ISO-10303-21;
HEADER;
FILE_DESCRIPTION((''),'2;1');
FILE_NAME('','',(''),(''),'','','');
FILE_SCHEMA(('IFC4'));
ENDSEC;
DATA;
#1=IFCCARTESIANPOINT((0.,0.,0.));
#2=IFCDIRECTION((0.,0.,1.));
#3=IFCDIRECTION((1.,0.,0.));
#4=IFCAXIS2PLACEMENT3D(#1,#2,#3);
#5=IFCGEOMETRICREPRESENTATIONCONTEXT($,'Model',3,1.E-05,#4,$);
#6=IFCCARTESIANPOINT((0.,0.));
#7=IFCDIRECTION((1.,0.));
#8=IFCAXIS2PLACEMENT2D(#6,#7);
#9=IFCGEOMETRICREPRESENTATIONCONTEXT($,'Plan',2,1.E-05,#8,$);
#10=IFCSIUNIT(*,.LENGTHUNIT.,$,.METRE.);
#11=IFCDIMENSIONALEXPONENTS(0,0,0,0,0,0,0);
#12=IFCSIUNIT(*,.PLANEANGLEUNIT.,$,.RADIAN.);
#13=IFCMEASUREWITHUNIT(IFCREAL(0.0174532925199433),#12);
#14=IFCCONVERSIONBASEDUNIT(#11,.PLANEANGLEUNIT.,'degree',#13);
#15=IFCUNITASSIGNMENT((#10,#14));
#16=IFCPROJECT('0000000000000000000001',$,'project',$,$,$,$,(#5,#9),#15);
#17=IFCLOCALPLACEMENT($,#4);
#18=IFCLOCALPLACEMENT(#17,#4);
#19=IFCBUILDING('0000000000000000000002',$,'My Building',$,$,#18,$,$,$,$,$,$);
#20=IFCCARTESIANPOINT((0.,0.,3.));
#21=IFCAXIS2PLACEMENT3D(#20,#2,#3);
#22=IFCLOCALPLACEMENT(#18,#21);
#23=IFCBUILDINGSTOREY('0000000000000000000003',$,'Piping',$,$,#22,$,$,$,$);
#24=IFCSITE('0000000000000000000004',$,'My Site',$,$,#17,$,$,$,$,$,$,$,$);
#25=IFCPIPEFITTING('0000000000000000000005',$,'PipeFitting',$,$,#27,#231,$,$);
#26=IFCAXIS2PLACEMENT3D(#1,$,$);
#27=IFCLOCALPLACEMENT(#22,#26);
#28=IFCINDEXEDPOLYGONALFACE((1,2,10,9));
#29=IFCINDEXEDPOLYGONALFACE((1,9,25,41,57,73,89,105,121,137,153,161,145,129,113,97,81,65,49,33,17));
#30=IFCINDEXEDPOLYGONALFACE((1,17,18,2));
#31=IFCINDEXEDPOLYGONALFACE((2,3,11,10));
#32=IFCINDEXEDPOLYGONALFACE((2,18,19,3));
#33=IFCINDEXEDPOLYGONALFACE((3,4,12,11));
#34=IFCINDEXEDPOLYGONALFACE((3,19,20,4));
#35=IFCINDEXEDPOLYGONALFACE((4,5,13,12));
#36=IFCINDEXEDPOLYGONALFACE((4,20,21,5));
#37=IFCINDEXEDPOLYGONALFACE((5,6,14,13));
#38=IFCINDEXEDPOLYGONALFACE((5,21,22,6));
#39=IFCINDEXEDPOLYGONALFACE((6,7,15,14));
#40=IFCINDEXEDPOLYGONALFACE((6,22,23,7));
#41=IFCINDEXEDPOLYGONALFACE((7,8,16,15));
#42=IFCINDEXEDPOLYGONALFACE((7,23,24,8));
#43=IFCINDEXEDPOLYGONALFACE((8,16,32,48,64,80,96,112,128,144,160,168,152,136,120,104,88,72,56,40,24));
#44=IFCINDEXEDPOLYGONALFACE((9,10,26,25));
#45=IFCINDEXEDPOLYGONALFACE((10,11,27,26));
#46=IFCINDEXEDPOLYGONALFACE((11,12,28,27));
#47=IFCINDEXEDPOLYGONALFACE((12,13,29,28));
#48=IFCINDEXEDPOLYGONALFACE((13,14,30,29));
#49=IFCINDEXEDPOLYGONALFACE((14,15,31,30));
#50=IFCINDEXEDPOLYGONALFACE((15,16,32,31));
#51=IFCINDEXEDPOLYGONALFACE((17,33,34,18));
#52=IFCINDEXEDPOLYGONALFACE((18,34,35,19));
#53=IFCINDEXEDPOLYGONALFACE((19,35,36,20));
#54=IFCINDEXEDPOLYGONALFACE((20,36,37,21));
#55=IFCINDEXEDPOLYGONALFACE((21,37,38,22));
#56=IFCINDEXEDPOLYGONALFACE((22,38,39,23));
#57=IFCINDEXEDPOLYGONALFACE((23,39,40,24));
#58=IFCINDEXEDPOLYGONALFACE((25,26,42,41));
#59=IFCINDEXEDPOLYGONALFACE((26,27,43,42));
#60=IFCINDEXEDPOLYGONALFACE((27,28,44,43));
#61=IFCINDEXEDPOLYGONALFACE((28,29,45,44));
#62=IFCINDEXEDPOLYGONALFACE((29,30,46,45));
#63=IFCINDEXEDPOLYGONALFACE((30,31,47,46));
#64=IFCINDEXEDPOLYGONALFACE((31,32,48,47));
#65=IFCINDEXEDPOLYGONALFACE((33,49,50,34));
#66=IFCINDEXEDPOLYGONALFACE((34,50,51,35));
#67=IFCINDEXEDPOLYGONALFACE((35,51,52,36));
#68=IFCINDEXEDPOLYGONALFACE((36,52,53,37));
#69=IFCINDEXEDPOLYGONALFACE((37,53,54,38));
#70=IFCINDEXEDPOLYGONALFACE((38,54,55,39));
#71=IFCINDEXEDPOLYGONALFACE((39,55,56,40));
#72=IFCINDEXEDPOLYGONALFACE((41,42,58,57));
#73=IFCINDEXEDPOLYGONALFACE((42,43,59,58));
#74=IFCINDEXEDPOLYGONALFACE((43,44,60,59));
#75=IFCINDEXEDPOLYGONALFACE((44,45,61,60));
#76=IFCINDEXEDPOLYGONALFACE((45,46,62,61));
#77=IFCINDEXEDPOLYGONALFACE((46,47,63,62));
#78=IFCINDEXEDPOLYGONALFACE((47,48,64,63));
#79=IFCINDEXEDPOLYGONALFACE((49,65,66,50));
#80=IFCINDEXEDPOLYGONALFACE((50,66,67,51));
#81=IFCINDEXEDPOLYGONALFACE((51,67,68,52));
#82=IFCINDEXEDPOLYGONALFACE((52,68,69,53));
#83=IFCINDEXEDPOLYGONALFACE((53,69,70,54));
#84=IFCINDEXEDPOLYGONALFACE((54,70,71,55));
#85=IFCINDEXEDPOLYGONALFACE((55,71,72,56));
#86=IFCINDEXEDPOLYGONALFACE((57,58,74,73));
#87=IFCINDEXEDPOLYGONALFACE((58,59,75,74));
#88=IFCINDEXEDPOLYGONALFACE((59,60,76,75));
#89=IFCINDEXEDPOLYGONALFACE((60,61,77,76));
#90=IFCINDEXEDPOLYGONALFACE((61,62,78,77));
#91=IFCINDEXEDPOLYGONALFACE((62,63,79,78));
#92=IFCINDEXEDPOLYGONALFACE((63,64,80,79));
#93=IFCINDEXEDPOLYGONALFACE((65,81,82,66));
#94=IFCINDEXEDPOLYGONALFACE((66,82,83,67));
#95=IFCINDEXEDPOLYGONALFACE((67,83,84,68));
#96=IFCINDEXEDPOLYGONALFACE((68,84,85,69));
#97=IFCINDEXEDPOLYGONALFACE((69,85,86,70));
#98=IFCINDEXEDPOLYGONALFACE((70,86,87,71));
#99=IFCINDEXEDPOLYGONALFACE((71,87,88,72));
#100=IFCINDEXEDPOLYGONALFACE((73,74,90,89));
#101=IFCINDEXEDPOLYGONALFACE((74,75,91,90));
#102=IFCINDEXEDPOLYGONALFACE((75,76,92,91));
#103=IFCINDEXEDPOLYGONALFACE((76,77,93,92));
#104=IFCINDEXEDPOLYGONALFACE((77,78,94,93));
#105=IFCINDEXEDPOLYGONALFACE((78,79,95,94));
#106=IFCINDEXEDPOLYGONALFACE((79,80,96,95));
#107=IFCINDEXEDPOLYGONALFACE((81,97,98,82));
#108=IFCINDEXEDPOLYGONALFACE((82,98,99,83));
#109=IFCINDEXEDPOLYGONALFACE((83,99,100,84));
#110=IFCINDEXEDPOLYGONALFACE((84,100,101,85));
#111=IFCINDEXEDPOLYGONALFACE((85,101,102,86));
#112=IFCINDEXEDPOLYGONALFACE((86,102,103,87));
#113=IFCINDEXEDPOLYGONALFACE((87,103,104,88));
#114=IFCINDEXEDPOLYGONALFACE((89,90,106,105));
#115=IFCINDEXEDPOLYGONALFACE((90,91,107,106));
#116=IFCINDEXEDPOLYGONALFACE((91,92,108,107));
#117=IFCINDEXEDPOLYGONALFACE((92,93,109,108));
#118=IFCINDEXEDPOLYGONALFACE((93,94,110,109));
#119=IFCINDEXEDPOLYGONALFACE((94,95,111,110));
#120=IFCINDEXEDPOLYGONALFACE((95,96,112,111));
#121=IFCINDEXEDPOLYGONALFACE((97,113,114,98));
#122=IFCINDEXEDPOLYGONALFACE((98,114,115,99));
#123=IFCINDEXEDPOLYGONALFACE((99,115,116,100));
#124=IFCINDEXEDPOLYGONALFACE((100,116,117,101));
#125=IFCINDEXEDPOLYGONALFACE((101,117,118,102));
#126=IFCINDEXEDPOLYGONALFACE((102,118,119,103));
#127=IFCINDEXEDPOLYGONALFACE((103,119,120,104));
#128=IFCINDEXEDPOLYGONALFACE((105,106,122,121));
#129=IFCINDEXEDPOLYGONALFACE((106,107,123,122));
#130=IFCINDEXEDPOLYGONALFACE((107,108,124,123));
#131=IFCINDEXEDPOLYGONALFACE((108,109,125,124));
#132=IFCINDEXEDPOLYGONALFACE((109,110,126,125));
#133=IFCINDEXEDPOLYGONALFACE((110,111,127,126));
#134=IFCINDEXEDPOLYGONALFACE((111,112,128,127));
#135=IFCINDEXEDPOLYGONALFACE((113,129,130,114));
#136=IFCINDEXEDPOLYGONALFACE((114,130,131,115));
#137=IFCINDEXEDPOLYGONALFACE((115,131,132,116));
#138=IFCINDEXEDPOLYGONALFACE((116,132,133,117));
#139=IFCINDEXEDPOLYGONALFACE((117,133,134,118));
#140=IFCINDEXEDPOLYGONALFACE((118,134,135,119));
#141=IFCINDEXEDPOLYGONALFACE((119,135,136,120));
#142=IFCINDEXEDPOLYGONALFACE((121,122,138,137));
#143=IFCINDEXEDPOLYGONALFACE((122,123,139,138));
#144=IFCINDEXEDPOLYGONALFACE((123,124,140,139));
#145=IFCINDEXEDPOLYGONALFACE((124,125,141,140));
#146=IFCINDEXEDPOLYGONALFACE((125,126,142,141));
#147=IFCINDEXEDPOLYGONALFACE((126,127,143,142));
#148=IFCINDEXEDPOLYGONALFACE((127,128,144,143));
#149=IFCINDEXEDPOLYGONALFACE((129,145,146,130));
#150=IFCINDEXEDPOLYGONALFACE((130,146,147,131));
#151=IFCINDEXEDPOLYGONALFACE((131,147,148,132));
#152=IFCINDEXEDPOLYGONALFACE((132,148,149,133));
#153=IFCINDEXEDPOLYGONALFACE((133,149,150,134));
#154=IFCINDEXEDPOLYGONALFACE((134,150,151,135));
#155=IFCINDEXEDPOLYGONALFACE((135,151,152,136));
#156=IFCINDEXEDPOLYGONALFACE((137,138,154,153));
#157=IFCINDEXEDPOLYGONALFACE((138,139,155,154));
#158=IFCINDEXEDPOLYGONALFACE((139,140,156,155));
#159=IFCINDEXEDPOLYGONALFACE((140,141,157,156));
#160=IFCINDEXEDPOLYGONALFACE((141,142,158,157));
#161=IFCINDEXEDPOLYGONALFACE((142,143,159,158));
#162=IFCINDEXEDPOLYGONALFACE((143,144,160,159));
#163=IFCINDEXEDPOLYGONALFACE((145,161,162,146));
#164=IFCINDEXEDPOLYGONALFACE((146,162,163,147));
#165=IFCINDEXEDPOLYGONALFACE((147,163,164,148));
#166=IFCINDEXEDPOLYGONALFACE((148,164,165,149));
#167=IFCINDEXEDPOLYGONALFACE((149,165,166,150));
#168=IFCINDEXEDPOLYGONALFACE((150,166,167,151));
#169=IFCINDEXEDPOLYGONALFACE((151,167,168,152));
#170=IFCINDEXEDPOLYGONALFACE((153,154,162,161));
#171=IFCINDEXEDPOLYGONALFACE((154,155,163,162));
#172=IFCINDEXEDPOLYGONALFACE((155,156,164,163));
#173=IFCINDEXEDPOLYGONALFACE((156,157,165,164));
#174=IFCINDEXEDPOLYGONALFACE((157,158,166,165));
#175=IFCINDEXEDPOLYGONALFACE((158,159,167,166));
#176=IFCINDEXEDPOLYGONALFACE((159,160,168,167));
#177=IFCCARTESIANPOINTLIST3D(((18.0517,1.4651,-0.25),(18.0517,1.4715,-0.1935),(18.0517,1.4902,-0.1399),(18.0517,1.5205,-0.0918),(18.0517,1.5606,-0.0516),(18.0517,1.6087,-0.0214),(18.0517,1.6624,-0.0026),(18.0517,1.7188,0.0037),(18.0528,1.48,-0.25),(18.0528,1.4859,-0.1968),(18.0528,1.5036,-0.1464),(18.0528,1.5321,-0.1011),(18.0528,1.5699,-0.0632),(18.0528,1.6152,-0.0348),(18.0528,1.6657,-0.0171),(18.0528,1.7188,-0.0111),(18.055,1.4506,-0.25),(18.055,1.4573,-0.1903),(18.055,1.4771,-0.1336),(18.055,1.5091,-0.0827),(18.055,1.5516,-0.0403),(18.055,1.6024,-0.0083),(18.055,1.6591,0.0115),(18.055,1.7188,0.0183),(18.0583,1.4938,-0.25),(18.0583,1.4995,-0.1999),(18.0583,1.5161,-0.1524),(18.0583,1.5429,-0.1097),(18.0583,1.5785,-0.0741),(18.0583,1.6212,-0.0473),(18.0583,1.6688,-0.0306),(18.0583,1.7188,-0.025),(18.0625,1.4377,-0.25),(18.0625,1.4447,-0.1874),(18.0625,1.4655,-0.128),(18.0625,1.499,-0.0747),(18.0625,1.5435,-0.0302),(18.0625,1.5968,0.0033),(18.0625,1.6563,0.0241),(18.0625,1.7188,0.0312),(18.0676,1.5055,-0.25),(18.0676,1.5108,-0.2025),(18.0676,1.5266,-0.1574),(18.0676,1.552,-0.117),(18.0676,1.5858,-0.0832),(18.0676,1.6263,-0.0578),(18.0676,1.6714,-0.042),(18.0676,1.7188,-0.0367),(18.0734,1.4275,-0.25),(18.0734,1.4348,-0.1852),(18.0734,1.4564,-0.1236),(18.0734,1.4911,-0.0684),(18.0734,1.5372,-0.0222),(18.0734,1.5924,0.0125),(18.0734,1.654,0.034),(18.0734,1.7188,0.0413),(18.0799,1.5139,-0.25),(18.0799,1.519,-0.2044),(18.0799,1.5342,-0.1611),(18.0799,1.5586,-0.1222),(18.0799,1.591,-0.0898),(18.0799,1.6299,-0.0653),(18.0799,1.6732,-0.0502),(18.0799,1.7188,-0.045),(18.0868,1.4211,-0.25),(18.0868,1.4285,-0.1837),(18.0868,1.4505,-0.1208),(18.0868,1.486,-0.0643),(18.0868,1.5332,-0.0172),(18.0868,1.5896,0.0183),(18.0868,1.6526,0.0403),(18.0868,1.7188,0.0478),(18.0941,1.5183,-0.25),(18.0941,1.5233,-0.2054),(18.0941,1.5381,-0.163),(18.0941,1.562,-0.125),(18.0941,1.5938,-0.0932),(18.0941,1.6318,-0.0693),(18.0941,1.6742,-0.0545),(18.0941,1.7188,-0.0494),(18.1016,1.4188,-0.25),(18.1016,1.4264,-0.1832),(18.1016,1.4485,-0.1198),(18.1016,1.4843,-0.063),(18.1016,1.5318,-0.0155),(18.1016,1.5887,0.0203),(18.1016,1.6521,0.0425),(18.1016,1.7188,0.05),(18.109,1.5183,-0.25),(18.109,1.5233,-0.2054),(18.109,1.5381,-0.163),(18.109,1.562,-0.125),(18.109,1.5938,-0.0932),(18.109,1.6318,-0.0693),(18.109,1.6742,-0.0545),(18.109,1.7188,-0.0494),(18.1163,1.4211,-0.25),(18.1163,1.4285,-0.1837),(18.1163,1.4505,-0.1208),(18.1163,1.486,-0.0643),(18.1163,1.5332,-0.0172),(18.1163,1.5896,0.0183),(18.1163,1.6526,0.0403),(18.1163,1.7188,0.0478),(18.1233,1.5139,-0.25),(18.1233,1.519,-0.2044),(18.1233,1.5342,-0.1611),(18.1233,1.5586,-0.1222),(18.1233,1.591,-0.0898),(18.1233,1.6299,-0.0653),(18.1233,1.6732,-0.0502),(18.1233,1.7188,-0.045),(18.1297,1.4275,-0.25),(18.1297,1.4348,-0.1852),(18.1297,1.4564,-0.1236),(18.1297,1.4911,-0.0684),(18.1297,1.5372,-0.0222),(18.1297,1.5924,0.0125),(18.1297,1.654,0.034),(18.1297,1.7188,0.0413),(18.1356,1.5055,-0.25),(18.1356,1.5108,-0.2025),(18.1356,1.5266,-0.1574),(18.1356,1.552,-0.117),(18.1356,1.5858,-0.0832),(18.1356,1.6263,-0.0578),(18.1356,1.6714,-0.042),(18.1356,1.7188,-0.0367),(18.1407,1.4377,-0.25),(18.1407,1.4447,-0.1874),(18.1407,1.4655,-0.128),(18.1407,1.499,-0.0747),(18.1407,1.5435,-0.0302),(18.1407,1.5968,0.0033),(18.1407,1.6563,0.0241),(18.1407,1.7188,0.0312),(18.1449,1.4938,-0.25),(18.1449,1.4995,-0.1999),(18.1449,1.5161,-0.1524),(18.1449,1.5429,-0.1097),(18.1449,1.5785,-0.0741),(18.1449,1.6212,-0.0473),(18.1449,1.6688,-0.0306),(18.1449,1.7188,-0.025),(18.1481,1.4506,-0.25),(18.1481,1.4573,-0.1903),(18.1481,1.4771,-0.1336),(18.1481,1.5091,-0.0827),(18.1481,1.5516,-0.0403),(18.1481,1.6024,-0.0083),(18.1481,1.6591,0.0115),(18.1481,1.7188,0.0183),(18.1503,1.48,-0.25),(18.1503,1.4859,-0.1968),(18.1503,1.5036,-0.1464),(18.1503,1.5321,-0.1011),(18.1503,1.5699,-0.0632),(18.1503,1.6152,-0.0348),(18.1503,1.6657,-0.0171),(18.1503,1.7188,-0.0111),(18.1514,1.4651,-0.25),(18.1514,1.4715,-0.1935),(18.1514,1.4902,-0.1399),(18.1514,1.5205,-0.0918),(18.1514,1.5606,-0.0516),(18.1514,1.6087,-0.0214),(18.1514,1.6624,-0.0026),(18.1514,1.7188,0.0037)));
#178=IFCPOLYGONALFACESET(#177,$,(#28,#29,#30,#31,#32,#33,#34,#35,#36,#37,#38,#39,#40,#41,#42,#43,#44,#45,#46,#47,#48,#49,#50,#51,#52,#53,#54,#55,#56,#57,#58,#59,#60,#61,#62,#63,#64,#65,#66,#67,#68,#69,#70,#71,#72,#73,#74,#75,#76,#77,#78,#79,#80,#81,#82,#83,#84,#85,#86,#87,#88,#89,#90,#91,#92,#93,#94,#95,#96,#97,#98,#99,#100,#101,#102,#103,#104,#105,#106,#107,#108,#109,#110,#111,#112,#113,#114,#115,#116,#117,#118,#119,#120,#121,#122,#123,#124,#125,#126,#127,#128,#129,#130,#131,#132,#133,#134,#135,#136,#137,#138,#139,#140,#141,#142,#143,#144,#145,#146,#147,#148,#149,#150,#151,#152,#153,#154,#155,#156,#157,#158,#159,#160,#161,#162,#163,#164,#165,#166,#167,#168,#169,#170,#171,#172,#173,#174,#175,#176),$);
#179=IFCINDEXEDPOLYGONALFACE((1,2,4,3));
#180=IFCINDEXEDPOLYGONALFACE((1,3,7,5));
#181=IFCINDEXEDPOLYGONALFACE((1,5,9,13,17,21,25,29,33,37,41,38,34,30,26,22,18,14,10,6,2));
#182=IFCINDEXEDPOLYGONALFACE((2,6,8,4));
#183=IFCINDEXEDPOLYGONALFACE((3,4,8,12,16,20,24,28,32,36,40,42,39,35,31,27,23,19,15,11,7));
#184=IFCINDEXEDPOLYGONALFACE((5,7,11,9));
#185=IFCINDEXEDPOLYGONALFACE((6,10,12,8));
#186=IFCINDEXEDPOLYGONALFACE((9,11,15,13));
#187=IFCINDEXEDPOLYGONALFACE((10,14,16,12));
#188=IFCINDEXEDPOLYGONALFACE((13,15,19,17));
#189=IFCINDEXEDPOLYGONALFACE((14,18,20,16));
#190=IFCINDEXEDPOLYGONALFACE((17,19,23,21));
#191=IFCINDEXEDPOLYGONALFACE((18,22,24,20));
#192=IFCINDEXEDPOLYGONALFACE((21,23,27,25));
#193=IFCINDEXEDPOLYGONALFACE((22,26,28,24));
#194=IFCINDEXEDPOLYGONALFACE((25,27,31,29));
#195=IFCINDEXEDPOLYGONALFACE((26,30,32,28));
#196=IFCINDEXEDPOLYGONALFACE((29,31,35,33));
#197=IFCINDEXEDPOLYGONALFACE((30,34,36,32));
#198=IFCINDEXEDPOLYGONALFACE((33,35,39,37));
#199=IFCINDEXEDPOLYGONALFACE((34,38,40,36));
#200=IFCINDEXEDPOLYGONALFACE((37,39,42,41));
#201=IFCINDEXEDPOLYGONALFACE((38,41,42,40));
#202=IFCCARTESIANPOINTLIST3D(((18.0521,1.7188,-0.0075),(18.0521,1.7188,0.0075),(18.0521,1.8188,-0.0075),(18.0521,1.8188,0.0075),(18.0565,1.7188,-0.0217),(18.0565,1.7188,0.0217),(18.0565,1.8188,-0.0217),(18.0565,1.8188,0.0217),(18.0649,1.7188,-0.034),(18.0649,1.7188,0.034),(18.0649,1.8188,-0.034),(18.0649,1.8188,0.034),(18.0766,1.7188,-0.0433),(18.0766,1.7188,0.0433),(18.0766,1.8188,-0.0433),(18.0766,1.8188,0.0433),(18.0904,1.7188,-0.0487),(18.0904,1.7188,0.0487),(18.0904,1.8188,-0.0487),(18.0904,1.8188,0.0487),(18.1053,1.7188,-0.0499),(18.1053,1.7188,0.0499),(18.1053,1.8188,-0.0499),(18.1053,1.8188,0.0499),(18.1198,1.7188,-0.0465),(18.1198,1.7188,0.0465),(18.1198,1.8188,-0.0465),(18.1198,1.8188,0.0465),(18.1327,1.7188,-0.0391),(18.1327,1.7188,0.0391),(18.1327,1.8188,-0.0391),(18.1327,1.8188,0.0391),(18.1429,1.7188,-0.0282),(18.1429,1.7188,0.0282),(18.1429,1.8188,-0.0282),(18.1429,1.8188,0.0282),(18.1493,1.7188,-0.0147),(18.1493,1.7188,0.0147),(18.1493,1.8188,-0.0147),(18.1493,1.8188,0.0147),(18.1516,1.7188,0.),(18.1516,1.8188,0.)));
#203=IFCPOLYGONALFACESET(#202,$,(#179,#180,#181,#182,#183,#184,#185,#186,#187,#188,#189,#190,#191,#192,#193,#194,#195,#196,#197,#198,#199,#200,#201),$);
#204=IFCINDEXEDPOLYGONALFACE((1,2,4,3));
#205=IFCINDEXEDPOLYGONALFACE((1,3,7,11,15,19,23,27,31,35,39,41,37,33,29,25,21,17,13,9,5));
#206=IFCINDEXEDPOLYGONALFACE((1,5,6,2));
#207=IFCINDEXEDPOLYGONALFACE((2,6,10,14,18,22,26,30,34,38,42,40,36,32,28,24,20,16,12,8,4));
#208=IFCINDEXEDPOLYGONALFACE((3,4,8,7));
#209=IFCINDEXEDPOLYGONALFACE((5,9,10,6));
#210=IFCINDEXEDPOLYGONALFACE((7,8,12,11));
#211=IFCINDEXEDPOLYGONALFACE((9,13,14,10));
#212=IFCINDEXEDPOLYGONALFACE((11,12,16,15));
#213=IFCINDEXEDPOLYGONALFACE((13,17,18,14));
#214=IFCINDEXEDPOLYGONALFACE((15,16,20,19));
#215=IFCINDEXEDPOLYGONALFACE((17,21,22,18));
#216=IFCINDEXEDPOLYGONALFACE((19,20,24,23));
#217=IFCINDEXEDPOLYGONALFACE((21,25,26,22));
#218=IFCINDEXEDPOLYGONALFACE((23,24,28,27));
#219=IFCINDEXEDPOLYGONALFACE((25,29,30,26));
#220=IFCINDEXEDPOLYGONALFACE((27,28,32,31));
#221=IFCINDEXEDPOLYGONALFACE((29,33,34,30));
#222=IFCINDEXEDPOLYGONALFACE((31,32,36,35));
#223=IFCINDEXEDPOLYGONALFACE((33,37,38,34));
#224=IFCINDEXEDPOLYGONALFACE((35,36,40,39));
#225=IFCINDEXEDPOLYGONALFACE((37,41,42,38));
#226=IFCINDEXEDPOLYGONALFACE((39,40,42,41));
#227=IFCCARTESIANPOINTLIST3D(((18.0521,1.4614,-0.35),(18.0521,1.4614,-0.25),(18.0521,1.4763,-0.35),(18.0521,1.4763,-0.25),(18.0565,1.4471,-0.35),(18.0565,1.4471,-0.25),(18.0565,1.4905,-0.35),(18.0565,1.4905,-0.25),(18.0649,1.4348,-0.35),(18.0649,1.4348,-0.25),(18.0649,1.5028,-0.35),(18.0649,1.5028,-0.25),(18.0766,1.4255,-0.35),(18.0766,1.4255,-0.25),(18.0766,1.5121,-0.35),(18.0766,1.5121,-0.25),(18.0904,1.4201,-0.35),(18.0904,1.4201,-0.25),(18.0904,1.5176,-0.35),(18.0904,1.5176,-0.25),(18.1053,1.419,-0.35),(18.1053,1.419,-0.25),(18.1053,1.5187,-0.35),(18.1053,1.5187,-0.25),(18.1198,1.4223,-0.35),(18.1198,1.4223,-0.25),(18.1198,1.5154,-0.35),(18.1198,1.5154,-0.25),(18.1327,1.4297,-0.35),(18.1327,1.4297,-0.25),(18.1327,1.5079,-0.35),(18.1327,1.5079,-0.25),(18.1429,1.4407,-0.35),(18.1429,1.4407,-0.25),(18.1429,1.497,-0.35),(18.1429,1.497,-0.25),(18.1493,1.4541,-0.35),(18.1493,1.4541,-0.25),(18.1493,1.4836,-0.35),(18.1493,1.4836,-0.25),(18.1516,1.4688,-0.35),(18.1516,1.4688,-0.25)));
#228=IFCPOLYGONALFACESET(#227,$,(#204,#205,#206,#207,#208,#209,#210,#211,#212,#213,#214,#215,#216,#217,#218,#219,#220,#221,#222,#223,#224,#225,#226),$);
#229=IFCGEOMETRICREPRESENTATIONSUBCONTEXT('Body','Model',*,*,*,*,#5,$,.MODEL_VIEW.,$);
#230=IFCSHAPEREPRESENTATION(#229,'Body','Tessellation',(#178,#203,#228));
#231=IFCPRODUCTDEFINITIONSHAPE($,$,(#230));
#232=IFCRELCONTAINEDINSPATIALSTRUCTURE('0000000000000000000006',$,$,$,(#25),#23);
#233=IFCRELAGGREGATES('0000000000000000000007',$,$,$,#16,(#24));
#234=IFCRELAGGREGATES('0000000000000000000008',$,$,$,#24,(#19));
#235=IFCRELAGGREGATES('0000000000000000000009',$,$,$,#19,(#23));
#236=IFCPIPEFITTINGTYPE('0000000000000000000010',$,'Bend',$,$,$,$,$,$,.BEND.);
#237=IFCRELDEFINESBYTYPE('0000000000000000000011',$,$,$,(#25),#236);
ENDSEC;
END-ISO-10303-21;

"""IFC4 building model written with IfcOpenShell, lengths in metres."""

from ifc_helpers import new_model, entity, si_unit, converted_unit, frame, origin_with_axes, origin_2d_with_axis, place, context, subcontext, project, spatial, circle, extrude, source, transform, mapped, type_object, type_shapes, element, save


model = new_model("IFC4")

# Units and contexts
model_context = context("Model", 3, precision=1e-05, world=origin_with_axes())
plan_context = context("Plan", 2, precision=1e-05, world=origin_2d_with_axis())
body_context = subcontext(model_context, "Body", "Model", "MODEL_VIEW")
ifc_project = project(units=[si_unit("LENGTHUNIT", "METRE"), converted_unit("PLANEANGLEUNIT", "degree", entity("IfcReal", 0.0174532925199433), si_unit("PLANEANGLEUNIT", "RADIAN"), dimensions=[0, 0, 0, 0, 0, 0, 0])], contexts=[model_context, plan_context])

# Site, building, storey
site_placement = place(None, origin_with_axes())
site = spatial("IfcSite", under=ifc_project, at=site_placement, Name="My Site")
building_placement = place(site_placement, origin_with_axes())
building = spatial("IfcBuilding", under=site, at=building_placement, Name="My Building")
storey_placement = place(building_placement, frame((0.0, 0.0, 3.0), z_axis=(0.0, 0.0, 1.0), x_axis=(1.0, 0.0, 0.0)))
storey = spatial("IfcBuildingStorey", under=building, at=storey_placement, Name="Piping")

# Shared definitions
pipe_fitting_type = type_object("IfcPipeFittingType", Name="Bend", PredefinedType="BEND")
shared_shape = source(origin_with_axes(), body_context, "Body", "SolidModel", [
    entity("IfcSweptDiskSolid", entity("IfcIndexedPolyCurve", entity("IfcCartesianPointList3D", [[0.0, 0.0, -0.1], [0.0, 0.0732, -0.2768], [0.0, 0.25, -0.35]]), [entity("IfcArcIndex", [1, 2, 3])]), 0.05),
    extrude(circle(Radius=0.05), origin_with_axes(), (0.0, 0.0, -1.0), 0.1),
    extrude(circle(Radius=0.05), frame((0.0, 0.25, -0.35), z_axis=(0.0, 1.0, 0.0), x_axis=(1.0, 0.0, 0.0)), (0.0, 0.0, 1.0), 0.1),
])
type_shapes(pipe_fitting_type, [shared_shape])

# Pipe fitting
for number, where, z_axis, x_axis, name in (
    (1, (18.1016, 1.8188, 0.0), (0.0, 1.0, 0.0), (1.0, 0.0, 0.0), "PipeFitting"),
):
    element("IfcPipeFitting", number, at=place(storey_placement, frame(where, z_axis=z_axis, x_axis=x_axis)), inside=storey, type_object=pipe_fitting_type, Name=name, context=body_context, shape_type="MappedRepresentation", body=[
        mapped(shared_shape, transform((0.0, 0.0, 0.0), x_axis=(1.0, 0.0, 0.0), y_axis=(0.0, 1.0, 0.0), z_axis=(0.0, 0.0, 1.0), scale=1.0)),
    ])

save(model, "model.ifc")
